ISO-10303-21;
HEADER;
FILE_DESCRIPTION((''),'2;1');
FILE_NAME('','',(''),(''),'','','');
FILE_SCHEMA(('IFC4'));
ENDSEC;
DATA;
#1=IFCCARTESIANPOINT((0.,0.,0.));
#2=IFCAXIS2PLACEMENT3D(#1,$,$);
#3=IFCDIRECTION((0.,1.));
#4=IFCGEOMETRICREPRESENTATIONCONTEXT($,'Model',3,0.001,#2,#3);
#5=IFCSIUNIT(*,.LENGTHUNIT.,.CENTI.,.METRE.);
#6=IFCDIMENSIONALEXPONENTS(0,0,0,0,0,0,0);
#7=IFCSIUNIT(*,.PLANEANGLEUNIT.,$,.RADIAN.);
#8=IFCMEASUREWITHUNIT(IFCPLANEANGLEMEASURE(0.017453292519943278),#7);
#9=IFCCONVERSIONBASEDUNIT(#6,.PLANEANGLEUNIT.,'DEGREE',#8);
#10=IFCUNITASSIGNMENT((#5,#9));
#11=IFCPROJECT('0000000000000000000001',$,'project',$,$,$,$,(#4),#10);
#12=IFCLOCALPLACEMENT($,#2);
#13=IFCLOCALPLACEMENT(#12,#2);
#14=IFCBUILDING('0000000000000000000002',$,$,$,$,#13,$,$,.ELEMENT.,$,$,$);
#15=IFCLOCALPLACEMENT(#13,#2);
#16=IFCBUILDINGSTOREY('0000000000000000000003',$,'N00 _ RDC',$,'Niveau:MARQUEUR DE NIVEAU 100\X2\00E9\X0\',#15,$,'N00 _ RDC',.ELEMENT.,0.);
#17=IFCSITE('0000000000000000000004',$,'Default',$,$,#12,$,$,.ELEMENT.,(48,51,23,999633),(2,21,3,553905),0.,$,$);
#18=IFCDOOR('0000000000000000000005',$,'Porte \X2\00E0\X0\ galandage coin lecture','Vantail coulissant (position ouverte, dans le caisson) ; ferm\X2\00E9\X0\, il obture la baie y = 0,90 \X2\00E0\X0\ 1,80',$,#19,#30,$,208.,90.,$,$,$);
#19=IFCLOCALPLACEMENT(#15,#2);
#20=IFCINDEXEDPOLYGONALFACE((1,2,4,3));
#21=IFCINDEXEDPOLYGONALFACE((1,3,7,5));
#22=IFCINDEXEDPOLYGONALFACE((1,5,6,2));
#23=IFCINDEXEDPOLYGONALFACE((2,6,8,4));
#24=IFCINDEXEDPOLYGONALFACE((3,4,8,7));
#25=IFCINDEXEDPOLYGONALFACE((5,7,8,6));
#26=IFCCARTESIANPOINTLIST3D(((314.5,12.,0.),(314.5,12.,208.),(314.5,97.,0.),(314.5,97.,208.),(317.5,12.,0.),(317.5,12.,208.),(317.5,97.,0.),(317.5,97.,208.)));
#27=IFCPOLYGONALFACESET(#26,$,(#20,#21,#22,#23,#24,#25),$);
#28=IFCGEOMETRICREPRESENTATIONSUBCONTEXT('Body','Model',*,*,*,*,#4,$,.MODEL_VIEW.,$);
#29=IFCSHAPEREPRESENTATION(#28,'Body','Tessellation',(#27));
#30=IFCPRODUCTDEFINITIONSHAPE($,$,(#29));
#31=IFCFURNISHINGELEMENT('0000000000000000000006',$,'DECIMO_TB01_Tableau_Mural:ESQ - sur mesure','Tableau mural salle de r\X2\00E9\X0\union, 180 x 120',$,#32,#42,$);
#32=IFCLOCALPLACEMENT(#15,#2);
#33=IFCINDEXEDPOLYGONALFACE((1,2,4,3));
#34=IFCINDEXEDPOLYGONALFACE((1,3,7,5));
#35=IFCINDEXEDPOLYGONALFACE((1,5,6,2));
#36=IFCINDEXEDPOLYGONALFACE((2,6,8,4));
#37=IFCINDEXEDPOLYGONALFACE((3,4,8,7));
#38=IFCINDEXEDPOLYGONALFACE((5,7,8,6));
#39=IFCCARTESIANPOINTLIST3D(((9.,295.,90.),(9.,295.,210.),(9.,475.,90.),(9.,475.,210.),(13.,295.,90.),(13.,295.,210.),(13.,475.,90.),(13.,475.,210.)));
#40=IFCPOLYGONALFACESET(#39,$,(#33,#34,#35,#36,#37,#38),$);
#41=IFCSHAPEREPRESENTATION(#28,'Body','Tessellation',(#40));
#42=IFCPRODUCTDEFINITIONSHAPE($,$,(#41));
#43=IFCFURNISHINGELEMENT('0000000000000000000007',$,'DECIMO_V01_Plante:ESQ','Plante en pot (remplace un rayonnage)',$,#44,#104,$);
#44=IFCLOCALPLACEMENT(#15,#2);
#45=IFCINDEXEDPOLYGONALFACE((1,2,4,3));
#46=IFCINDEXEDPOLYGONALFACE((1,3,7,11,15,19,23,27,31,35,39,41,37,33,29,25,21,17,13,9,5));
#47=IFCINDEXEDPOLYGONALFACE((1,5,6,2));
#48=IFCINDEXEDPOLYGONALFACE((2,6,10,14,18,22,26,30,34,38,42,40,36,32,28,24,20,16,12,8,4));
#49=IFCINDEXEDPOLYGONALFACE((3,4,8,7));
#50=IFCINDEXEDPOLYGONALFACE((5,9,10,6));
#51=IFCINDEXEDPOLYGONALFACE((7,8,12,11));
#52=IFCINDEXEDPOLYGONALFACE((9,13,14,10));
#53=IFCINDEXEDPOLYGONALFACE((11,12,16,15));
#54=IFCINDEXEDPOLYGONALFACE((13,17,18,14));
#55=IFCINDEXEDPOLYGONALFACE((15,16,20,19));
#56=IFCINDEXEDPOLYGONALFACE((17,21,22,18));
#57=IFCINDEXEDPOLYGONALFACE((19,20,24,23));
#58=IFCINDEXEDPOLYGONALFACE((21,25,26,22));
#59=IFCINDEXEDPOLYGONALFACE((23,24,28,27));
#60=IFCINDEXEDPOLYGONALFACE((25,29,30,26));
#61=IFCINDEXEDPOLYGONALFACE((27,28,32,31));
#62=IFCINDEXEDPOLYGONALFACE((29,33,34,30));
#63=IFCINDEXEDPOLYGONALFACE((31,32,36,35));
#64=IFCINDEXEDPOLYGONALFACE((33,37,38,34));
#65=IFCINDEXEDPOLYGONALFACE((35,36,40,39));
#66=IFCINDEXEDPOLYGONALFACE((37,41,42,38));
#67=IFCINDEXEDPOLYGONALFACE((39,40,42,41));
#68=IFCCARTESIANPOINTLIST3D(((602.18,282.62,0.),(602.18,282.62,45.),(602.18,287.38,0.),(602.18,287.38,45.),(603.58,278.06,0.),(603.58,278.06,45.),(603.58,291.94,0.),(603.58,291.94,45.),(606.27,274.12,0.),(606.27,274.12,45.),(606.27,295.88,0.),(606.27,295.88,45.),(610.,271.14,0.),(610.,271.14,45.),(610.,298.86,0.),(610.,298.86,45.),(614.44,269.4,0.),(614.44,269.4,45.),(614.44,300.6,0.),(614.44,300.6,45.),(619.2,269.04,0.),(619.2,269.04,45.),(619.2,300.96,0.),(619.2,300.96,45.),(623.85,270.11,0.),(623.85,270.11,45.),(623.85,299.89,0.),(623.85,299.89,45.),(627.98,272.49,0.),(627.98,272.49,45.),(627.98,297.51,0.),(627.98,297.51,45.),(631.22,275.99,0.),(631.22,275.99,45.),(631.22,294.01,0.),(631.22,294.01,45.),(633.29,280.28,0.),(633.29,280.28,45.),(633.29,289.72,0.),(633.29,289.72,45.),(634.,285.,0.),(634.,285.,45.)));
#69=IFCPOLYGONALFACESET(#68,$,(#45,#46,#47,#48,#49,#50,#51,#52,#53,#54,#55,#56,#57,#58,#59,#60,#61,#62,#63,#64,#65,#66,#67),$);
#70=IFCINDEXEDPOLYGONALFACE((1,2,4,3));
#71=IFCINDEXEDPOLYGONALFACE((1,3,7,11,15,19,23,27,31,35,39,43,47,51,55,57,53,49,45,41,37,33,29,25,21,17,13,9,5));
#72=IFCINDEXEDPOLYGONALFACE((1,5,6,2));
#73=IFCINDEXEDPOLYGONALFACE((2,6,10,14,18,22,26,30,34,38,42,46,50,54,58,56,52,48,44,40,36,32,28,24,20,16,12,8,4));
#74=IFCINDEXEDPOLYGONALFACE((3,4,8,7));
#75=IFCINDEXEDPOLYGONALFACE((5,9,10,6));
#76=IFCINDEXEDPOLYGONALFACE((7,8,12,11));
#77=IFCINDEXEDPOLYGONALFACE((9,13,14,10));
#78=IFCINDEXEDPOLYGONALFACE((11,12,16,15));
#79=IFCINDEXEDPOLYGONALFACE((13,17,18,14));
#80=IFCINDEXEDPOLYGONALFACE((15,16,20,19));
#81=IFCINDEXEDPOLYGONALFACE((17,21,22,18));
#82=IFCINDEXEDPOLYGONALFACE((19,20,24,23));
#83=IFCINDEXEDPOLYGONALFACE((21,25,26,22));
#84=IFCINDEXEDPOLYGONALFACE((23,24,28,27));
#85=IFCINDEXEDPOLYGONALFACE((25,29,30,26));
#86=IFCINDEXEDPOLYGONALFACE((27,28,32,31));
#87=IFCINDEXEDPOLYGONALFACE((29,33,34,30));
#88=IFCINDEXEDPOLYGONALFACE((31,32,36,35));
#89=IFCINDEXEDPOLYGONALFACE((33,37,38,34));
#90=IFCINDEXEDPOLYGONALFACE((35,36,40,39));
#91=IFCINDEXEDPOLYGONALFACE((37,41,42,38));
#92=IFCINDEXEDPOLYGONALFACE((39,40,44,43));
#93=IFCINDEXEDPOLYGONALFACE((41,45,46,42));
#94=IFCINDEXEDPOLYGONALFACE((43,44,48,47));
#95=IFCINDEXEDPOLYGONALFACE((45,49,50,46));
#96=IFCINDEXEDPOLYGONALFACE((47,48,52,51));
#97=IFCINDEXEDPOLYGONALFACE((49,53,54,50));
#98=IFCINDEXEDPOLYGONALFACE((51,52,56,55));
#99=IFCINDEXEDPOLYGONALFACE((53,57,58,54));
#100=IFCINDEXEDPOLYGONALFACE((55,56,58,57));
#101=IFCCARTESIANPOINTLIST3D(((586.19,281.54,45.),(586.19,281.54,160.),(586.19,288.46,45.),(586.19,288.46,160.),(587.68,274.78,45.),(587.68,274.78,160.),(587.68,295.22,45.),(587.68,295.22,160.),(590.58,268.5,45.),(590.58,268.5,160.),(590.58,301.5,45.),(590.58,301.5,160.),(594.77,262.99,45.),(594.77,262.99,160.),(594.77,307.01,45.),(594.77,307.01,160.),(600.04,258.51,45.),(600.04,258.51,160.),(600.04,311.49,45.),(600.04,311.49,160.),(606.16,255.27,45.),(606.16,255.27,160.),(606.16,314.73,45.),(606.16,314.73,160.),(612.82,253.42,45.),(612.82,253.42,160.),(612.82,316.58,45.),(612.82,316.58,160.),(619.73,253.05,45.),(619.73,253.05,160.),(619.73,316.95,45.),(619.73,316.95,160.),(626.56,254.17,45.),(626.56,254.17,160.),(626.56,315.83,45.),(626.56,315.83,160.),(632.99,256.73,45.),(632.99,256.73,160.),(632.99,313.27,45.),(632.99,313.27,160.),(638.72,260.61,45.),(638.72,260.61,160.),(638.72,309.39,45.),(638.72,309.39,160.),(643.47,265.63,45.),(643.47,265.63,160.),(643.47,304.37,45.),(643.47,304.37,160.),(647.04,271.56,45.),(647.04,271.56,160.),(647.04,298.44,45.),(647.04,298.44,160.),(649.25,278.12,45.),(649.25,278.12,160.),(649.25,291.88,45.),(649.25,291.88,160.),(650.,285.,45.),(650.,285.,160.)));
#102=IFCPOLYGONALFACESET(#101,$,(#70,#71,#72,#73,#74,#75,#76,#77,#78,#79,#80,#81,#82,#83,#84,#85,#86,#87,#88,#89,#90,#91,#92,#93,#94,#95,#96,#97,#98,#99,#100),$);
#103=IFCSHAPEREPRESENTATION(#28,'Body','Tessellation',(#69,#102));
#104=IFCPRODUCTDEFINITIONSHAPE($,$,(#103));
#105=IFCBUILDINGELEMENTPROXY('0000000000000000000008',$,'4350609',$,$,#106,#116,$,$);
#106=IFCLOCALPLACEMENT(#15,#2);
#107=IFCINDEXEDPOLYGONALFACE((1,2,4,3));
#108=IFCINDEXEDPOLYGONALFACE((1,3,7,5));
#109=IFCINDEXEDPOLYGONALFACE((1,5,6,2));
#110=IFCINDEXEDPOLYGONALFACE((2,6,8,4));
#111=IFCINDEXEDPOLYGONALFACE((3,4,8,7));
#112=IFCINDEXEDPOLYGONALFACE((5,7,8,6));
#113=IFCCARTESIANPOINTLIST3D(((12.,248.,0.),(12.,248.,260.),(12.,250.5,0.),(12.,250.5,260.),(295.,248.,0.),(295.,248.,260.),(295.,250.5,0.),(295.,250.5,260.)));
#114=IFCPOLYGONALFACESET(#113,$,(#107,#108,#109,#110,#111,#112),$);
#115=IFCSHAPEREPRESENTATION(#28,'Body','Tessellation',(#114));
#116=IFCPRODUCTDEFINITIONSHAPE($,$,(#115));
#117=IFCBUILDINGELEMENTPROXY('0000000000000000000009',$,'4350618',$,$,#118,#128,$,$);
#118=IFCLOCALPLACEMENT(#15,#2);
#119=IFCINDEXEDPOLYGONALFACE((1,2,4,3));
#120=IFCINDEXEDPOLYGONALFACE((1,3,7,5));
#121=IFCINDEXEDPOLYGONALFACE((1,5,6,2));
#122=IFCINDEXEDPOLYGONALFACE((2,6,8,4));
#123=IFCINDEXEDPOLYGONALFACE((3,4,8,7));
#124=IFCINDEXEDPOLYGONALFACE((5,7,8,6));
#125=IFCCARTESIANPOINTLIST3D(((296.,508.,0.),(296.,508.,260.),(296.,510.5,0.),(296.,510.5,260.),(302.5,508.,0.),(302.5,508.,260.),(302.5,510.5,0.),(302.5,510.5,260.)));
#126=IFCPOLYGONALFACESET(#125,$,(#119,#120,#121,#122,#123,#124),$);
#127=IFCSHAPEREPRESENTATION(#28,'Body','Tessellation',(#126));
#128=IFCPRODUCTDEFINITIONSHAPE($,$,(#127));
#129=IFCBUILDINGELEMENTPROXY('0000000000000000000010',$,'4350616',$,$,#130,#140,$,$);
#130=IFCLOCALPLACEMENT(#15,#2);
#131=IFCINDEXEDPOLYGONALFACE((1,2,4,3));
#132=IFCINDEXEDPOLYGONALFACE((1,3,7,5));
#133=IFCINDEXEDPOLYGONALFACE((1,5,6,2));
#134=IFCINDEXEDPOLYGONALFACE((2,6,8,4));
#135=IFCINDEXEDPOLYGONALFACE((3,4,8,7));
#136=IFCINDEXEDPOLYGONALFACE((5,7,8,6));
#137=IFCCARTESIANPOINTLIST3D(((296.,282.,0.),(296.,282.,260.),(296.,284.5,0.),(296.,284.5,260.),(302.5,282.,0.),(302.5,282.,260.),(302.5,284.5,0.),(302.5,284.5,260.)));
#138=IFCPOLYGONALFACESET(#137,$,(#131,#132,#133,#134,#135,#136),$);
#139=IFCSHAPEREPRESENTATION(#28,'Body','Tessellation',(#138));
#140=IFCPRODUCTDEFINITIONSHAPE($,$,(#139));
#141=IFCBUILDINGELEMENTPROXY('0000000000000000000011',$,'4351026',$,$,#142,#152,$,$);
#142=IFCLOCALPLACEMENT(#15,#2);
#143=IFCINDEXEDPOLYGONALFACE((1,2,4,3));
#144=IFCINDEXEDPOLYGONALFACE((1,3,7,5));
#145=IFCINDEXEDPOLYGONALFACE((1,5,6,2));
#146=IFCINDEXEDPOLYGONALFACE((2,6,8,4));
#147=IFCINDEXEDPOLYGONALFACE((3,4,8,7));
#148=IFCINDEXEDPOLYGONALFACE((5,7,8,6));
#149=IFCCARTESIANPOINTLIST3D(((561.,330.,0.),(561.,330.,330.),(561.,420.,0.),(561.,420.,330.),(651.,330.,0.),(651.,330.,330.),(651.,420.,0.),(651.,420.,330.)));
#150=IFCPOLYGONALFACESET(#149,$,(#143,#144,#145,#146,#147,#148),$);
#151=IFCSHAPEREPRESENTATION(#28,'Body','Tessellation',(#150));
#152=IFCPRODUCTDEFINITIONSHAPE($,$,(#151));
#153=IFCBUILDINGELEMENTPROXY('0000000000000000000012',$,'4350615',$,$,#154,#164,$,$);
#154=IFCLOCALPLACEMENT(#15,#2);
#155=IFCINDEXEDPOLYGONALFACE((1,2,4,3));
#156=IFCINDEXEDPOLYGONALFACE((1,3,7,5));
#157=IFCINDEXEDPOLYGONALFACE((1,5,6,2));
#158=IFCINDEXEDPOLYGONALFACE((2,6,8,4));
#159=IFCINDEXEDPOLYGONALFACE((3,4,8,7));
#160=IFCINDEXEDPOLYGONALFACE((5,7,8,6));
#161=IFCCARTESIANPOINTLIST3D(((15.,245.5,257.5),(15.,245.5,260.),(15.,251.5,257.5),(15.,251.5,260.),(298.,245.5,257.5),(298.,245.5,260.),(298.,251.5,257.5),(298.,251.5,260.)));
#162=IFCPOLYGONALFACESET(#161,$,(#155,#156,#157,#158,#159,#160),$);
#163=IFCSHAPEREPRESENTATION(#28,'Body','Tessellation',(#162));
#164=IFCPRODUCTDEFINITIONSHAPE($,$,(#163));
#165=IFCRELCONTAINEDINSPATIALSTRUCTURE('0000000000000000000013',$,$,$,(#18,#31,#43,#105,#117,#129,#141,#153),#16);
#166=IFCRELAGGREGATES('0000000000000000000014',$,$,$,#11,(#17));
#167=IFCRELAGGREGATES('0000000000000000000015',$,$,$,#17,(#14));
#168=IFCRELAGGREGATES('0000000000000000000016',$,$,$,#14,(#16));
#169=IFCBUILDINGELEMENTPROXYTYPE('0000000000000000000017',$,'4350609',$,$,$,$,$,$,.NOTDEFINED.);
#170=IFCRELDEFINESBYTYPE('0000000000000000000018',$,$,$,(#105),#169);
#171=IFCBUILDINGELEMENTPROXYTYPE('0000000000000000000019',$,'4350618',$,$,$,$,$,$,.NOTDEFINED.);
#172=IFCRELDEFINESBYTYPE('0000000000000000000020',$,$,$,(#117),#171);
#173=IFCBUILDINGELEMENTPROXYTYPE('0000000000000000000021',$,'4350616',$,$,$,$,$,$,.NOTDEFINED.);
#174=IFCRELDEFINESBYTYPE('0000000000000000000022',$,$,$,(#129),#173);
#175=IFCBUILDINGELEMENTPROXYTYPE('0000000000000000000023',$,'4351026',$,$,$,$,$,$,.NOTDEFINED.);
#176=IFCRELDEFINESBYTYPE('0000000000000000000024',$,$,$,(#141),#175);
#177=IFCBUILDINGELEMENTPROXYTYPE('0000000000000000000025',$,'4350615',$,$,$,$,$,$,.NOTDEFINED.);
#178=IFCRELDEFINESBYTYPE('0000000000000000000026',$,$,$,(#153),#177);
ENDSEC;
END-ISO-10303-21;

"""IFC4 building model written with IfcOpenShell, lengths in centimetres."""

from ifc_helpers import new_model, entity, si_unit, converted_unit, direction, frame, frame_2d, origin, origin_with_axes, place, context, subcontext, project, spatial, rectangle, circle, extrude, type_object, element, save


model = new_model("IFC4")

# Units and contexts
model_context = context("Model", 3, precision=0.001, world=origin(), true_north=direction((0.0, 1.0)))
body_context = subcontext(model_context, "Body", "Model", "MODEL_VIEW")
ifc_project = project(units=[si_unit("LENGTHUNIT", "METRE", prefix="CENTI"), converted_unit("PLANEANGLEUNIT", "DEGREE", entity("IfcPlaneAngleMeasure", 0.017453292519943278), si_unit("PLANEANGLEUNIT", "RADIAN"), dimensions=[0, 0, 0, 0, 0, 0, 0])], contexts=[model_context])

# Site, building, storey
site_placement = place(None, origin())
site = spatial("IfcSite", under=ifc_project, at=site_placement, Name="Default", CompositionType="ELEMENT", RefLatitude=(48, 51, 23, 999633), RefLongitude=(2, 21, 3, 553905), RefElevation=0.0)
building_placement = place(site_placement, origin())
building = spatial("IfcBuilding", under=site, at=building_placement, CompositionType="ELEMENT")
storey_placement = place(building_placement, origin())
storey = spatial("IfcBuildingStorey", under=building, at=storey_placement, Name="N00 _ RDC", ObjectType="Niveau:MARQUEUR DE NIVEAU 100é", LongName="N00 _ RDC", CompositionType="ELEMENT", Elevation=0.0)

# Door
door_placement = place(storey_placement, origin_with_axes())
element("IfcDoor", 1, at=door_placement, inside=storey, Name="Porte à galandage coin lecture", Description="Vantail coulissant (position ouverte, dans le caisson) ; fermé, il obture la baie y = 0,90 à 1,80", OverallHeight=208.0, OverallWidth=90.0, context=body_context, shape_type="SweptSolid", body=[
    extrude(rectangle(XDim=3.0, YDim=85.0, at=frame_2d((316.0, 54.5))), origin(), (0.0, 0.0, 1.0), 208.0),
])

# Furnishing elements
furnishing_1_placement = place(storey_placement, origin_with_axes())
element("IfcFurnishingElement", 2, at=furnishing_1_placement, inside=storey, Name="DECIMO_TB01_Tableau_Mural:ESQ - sur mesure", Description="Tableau mural salle de réunion, 180 x 120", context=body_context, shape_type="SweptSolid", body=[
    extrude(rectangle(XDim=4.0, YDim=180.0, at=frame_2d((11.0, 385.0))), frame((0.0, 0.0, 90.0)), (0.0, 0.0, 1.0), 120.0),
])
furnishing_2_placement = place(storey_placement, origin_with_axes())
element("IfcFurnishingElement", 3, at=furnishing_2_placement, inside=storey, Name="DECIMO_V01_Plante:ESQ", Description="Plante en pot (remplace un rayonnage)", context=body_context, shape_type="SweptSolid", body=[
    extrude(circle(Radius=16.0, at=frame_2d((618.0, 285.0))), origin(), (0.0, 0.0, 1.0), 45.0),
    extrude(circle(Radius=32.0, at=frame_2d((618.0, 285.0))), frame((0.0, 0.0, 45.0)), (0.0, 0.0, 1.0), 115.0),
])

# Building element proxies
building_element_proxy_type_1 = type_object("IfcBuildingElementProxyType", Name="4350609", PredefinedType="NOTDEFINED")
proxy_1_placement = place(storey_placement, origin())
element("IfcBuildingElementProxy", 4, at=proxy_1_placement, inside=storey, type_object=building_element_proxy_type_1, Name="4350609", context=body_context, shape_type="SweptSolid", body=[
    extrude(rectangle(XDim=283.0, YDim=2.5, at=frame_2d((0.0, 0.0), x_axis=(1.0, 0.0))), frame((153.5, 249.25, 0.0)), (0.0, 0.0, 1.0), 260.0),
])
building_element_proxy_type_2 = type_object("IfcBuildingElementProxyType", Name="4350618", PredefinedType="NOTDEFINED")
proxy_2_placement = place(storey_placement, origin())
element("IfcBuildingElementProxy", 5, at=proxy_2_placement, inside=storey, type_object=building_element_proxy_type_2, Name="4350618", context=body_context, shape_type="SweptSolid", body=[
    extrude(rectangle(XDim=6.5, YDim=2.5, at=frame_2d((0.0, 0.0), x_axis=(1.0, 0.0))), frame((299.25, 509.25, 0.0)), (0.0, 0.0, 1.0), 260.0),
])
building_element_proxy_type_3 = type_object("IfcBuildingElementProxyType", Name="4350616", PredefinedType="NOTDEFINED")
proxy_3_placement = place(storey_placement, origin())
element("IfcBuildingElementProxy", 6, at=proxy_3_placement, inside=storey, type_object=building_element_proxy_type_3, Name="4350616", context=body_context, shape_type="SweptSolid", body=[
    extrude(rectangle(XDim=6.5, YDim=2.5, at=frame_2d((0.0, 0.0), x_axis=(1.0, 0.0))), frame((299.25, 283.25, 0.0)), (0.0, 0.0, 1.0), 260.0),
])
building_element_proxy_type_4 = type_object("IfcBuildingElementProxyType", Name="4351026", PredefinedType="NOTDEFINED")
proxy_4_placement = place(storey_placement, origin())
element("IfcBuildingElementProxy", 7, at=proxy_4_placement, inside=storey, type_object=building_element_proxy_type_4, Name="4351026", context=body_context, shape_type="SweptSolid", body=[
    extrude(rectangle(XDim=90.0, YDim=90.0, at=frame_2d((0.0, 0.0), x_axis=(1.0, 0.0))), frame((606.0, 375.0, 0.0)), (0.0, 0.0, 1.0), 330.0),
])
building_element_proxy_type_5 = type_object("IfcBuildingElementProxyType", Name="4350615", PredefinedType="NOTDEFINED")
proxy_5_placement = place(storey_placement, origin())
element("IfcBuildingElementProxy", 8, at=proxy_5_placement, inside=storey, type_object=building_element_proxy_type_5, Name="4350615", context=body_context, shape_type="SweptSolid", body=[
    extrude(rectangle(XDim=283.0, YDim=6.0, at=frame_2d((0.0, 0.0), x_axis=(1.0, 0.0))), frame((156.5, 248.5, 257.5)), (0.0, 0.0, 1.0), 2.5),
])

save(model, "model.ifc")
